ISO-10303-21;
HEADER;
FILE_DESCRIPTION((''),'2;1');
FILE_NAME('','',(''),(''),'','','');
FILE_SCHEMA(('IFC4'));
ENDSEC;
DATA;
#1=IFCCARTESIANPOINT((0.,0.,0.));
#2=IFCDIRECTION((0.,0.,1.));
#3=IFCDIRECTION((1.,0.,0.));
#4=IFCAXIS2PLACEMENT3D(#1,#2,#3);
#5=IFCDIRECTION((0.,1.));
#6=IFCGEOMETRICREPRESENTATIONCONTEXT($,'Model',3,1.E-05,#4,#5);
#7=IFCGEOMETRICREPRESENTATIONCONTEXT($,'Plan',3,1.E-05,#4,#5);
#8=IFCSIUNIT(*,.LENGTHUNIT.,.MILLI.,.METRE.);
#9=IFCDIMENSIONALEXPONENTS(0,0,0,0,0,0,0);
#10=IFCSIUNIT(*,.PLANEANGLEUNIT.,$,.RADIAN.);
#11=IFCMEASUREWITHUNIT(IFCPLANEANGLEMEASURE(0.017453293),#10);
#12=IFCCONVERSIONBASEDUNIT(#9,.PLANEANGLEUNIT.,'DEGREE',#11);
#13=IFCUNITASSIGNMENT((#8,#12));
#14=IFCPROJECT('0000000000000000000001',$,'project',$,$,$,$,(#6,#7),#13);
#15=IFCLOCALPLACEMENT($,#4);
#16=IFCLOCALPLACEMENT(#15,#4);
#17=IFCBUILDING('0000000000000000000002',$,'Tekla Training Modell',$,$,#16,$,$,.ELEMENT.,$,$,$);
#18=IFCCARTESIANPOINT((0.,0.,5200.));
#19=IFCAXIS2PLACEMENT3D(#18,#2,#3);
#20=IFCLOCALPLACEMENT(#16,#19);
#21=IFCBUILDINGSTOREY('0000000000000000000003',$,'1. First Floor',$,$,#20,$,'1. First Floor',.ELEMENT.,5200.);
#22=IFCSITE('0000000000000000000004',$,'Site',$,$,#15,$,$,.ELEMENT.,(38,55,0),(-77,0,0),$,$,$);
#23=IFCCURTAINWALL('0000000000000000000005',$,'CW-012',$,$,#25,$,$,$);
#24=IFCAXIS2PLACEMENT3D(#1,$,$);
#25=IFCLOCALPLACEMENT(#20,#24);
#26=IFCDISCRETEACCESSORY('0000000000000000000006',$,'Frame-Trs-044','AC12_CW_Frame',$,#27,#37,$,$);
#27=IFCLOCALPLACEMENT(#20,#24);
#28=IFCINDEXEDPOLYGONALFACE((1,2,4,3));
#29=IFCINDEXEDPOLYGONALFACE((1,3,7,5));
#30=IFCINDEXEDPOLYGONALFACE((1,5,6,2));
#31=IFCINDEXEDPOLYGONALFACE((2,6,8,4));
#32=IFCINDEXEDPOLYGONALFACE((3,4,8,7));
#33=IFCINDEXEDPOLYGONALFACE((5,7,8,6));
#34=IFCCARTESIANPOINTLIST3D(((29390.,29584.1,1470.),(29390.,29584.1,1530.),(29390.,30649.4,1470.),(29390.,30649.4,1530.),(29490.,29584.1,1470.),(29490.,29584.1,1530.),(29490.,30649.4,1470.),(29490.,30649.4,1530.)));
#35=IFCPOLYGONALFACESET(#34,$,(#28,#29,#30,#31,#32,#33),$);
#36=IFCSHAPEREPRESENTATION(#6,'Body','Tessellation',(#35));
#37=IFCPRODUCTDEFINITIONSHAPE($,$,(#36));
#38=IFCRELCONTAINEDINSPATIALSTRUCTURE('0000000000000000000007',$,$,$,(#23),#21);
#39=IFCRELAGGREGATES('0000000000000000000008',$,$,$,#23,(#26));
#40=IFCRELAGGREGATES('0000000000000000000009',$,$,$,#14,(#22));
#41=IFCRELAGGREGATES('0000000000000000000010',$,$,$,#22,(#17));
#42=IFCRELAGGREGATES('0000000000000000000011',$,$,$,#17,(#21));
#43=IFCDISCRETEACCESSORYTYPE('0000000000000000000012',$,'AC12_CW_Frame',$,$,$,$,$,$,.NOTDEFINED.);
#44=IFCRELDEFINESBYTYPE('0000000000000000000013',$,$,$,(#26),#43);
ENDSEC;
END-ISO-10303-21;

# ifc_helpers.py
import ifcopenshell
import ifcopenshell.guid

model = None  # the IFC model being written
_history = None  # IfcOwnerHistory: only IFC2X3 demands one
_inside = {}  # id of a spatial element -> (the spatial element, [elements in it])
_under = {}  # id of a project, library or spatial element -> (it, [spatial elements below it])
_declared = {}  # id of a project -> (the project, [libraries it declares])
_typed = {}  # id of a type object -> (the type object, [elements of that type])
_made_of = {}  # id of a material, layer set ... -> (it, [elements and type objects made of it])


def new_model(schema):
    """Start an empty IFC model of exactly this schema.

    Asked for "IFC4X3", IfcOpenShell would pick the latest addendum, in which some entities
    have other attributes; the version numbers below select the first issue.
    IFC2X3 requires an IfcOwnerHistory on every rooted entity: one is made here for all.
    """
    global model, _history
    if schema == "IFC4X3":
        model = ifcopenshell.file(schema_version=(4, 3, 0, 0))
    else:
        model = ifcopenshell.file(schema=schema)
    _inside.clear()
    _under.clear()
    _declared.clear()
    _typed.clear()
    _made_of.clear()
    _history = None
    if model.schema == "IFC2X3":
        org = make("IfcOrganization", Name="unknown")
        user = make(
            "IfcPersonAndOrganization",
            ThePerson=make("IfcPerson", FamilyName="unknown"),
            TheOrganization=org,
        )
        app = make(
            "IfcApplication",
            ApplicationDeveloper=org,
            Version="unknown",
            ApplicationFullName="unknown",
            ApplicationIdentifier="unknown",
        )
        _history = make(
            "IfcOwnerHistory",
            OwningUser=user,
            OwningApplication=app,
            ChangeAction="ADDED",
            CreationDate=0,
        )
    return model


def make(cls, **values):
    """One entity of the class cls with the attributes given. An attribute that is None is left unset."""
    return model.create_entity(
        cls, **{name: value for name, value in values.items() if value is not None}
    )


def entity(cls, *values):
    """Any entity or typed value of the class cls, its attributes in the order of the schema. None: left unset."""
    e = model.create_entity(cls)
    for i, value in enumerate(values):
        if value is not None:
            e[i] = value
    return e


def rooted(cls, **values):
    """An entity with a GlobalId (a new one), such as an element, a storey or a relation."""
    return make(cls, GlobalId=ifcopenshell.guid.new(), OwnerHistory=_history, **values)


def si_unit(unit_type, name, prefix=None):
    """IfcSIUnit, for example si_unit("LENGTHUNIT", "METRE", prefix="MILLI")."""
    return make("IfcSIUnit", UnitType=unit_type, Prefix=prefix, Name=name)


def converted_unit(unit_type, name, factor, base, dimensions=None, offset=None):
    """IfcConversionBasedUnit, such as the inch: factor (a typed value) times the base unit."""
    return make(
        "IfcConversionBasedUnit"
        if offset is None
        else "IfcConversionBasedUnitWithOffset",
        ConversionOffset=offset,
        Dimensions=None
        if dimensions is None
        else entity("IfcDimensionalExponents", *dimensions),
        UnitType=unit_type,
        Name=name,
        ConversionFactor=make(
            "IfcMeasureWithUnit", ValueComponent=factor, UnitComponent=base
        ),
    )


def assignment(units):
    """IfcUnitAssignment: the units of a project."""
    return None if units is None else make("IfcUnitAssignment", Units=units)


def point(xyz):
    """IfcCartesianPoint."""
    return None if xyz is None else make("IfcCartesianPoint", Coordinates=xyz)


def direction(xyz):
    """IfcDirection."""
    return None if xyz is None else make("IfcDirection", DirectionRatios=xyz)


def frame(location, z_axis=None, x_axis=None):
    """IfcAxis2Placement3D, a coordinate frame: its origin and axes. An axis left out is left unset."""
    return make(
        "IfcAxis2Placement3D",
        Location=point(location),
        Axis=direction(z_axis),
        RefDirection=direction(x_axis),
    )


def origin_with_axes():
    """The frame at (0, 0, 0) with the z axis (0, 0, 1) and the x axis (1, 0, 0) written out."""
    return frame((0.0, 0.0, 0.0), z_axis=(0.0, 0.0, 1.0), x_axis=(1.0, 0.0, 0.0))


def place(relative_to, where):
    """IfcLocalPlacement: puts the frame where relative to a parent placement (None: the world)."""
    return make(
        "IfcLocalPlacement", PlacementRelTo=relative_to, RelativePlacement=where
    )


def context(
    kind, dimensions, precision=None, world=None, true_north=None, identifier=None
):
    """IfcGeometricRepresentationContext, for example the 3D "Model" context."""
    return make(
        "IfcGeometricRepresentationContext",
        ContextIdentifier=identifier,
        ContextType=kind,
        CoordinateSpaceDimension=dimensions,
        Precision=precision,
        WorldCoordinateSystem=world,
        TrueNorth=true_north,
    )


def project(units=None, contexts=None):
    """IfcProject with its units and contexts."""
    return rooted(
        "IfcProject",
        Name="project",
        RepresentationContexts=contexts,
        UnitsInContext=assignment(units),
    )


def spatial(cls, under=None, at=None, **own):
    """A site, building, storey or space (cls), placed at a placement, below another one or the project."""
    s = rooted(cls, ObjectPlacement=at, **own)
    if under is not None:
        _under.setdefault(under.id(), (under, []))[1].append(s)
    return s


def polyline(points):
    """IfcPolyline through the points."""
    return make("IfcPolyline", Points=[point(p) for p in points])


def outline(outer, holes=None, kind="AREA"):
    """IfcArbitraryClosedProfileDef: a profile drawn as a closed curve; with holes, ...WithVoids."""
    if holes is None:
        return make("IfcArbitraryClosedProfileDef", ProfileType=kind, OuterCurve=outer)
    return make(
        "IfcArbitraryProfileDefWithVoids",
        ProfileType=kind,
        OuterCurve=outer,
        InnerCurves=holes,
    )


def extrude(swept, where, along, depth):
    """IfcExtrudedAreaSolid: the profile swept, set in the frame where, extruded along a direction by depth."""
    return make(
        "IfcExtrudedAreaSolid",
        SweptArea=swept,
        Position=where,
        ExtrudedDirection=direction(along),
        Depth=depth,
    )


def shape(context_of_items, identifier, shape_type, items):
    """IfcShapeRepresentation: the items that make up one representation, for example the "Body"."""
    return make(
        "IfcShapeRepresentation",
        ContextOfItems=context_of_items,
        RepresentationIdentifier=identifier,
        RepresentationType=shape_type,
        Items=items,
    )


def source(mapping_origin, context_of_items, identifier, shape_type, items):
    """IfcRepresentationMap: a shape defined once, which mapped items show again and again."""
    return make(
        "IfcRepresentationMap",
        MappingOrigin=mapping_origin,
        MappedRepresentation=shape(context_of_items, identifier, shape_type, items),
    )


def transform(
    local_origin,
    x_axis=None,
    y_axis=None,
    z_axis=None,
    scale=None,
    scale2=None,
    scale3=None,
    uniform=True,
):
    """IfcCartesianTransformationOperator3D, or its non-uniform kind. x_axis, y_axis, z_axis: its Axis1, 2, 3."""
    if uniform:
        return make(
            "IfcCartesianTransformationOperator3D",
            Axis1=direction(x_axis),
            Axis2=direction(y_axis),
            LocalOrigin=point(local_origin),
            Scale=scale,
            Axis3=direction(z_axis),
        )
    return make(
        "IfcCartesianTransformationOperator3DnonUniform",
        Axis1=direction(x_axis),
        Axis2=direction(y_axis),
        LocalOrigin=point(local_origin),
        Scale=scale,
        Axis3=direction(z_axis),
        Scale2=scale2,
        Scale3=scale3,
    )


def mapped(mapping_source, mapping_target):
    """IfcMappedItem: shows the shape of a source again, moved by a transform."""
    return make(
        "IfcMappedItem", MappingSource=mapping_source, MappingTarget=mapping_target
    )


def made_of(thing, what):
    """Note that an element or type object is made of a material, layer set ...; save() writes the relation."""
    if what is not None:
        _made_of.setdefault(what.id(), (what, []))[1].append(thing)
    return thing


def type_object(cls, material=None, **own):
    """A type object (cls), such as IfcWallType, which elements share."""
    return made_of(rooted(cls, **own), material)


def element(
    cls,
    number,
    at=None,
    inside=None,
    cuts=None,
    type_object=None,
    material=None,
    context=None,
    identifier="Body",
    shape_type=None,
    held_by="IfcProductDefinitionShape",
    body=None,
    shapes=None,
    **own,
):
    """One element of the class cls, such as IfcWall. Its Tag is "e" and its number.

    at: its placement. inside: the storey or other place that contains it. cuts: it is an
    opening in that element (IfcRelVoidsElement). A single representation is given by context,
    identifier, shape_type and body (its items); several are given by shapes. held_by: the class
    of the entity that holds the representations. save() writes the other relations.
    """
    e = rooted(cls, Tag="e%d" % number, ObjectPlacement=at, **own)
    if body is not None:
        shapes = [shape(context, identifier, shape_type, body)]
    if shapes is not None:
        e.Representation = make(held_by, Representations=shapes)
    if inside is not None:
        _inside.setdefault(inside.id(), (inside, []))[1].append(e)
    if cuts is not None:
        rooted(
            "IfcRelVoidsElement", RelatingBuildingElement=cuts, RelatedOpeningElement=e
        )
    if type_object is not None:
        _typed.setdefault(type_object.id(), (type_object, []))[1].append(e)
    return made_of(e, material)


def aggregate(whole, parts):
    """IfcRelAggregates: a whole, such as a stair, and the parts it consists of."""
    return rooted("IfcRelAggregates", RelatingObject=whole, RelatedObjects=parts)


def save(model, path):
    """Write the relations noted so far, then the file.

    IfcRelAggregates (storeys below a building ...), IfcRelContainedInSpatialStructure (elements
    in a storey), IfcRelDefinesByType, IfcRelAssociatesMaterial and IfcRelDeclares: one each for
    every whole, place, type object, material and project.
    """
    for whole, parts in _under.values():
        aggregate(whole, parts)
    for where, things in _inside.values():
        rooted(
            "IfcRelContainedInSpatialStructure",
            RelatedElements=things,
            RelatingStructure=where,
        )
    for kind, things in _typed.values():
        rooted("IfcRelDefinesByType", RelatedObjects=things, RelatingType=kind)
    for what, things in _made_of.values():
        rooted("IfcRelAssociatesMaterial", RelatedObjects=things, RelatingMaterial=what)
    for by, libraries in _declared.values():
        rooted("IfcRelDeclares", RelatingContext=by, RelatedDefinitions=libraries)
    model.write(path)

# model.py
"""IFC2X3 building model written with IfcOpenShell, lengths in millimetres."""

from ifc_helpers import new_model, entity, si_unit, converted_unit, direction, frame, origin_with_axes, place, context, project, spatial, polyline, outline, extrude, source, transform, mapped, type_object, element, aggregate, save


model = new_model("IFC2X3")

# Units and contexts
model_context = context("Model", 3, precision=1e-05, world=origin_with_axes(), true_north=direction((0.0, 1.0)))
plan_context = context("Plan", 3, precision=1e-05, world=origin_with_axes(), true_north=direction((0.0, 1.0)))
ifc_project = project(units=[si_unit("LENGTHUNIT", "METRE", prefix="MILLI"), converted_unit("PLANEANGLEUNIT", "DEGREE", entity("IfcPlaneAngleMeasure", 0.017453293), si_unit("PLANEANGLEUNIT", "RADIAN"), dimensions=[0, 0, 0, 0, 0, 0, 0])], contexts=[model_context, plan_context])

# Site, building, storey
site_placement = place(None, origin_with_axes())
site = spatial("IfcSite", under=ifc_project, at=site_placement, Name="Site", CompositionType="ELEMENT", RefLatitude=(38, 55, 0), RefLongitude=(-77, 0, 0))
building_placement = place(site_placement, origin_with_axes())
building = spatial("IfcBuilding", under=site, at=building_placement, Name="Tekla Training Modell", CompositionType="ELEMENT")
storey_placement = place(building_placement, frame((0.0, 0.0, 5200.0), z_axis=(0.0, 0.0, 1.0), x_axis=(1.0, 0.0, 0.0)))
storey = spatial("IfcBuildingStorey", under=building, at=storey_placement, Name="1. First Floor", LongName="1. First Floor", CompositionType="ELEMENT", Elevation=5200.0)

# Curtain wall
curtain_wall_1_placement = place(storey_placement, frame((29500.0, 23544.1, 0.0), z_axis=(0.0, 0.0, 1.0), x_axis=(0.0, 1.0, 0.0)))
curtain_wall_1 = element("IfcCurtainWall", 1, at=curtain_wall_1_placement, inside=storey, Name="CW-012")

# Shared definitions
discrete_accessory_type = type_object("IfcDiscreteAccessoryType", Name="AC12_CW_Frame")

# Discrete accessory
shared_shape_1 = source(origin_with_axes(), model_context, "Body", "SweptSolid", [
    extrude(outline(polyline([(0.0, 0.0), (100.0, 0.0), (100.0, -1065.3), (0.0, -1065.3), (0.0, 0.0)])), origin_with_axes(), (0.0, 0.0, 1.0), 60.0),
])
discrete_accessory_1_placement = place(storey_placement, frame((29390.0, 29584.1, 1530.0), z_axis=(0.0, 0.0, -1.0), x_axis=(1.0, 0.0, 0.0)))
discrete_accessory_1 = element("IfcDiscreteAccessory", 2, at=discrete_accessory_1_placement, type_object=discrete_accessory_type, Name="Frame-Trs-044", Description="AC12_CW_Frame", context=model_context, shape_type="MappedRepresentation", body=[
    mapped(shared_shape_1, transform((0.0, 0.0, 0.0), scale=1.0)),
])
aggregate(curtain_wall_1, [discrete_accessory_1])

save(model, "model.ifc")
